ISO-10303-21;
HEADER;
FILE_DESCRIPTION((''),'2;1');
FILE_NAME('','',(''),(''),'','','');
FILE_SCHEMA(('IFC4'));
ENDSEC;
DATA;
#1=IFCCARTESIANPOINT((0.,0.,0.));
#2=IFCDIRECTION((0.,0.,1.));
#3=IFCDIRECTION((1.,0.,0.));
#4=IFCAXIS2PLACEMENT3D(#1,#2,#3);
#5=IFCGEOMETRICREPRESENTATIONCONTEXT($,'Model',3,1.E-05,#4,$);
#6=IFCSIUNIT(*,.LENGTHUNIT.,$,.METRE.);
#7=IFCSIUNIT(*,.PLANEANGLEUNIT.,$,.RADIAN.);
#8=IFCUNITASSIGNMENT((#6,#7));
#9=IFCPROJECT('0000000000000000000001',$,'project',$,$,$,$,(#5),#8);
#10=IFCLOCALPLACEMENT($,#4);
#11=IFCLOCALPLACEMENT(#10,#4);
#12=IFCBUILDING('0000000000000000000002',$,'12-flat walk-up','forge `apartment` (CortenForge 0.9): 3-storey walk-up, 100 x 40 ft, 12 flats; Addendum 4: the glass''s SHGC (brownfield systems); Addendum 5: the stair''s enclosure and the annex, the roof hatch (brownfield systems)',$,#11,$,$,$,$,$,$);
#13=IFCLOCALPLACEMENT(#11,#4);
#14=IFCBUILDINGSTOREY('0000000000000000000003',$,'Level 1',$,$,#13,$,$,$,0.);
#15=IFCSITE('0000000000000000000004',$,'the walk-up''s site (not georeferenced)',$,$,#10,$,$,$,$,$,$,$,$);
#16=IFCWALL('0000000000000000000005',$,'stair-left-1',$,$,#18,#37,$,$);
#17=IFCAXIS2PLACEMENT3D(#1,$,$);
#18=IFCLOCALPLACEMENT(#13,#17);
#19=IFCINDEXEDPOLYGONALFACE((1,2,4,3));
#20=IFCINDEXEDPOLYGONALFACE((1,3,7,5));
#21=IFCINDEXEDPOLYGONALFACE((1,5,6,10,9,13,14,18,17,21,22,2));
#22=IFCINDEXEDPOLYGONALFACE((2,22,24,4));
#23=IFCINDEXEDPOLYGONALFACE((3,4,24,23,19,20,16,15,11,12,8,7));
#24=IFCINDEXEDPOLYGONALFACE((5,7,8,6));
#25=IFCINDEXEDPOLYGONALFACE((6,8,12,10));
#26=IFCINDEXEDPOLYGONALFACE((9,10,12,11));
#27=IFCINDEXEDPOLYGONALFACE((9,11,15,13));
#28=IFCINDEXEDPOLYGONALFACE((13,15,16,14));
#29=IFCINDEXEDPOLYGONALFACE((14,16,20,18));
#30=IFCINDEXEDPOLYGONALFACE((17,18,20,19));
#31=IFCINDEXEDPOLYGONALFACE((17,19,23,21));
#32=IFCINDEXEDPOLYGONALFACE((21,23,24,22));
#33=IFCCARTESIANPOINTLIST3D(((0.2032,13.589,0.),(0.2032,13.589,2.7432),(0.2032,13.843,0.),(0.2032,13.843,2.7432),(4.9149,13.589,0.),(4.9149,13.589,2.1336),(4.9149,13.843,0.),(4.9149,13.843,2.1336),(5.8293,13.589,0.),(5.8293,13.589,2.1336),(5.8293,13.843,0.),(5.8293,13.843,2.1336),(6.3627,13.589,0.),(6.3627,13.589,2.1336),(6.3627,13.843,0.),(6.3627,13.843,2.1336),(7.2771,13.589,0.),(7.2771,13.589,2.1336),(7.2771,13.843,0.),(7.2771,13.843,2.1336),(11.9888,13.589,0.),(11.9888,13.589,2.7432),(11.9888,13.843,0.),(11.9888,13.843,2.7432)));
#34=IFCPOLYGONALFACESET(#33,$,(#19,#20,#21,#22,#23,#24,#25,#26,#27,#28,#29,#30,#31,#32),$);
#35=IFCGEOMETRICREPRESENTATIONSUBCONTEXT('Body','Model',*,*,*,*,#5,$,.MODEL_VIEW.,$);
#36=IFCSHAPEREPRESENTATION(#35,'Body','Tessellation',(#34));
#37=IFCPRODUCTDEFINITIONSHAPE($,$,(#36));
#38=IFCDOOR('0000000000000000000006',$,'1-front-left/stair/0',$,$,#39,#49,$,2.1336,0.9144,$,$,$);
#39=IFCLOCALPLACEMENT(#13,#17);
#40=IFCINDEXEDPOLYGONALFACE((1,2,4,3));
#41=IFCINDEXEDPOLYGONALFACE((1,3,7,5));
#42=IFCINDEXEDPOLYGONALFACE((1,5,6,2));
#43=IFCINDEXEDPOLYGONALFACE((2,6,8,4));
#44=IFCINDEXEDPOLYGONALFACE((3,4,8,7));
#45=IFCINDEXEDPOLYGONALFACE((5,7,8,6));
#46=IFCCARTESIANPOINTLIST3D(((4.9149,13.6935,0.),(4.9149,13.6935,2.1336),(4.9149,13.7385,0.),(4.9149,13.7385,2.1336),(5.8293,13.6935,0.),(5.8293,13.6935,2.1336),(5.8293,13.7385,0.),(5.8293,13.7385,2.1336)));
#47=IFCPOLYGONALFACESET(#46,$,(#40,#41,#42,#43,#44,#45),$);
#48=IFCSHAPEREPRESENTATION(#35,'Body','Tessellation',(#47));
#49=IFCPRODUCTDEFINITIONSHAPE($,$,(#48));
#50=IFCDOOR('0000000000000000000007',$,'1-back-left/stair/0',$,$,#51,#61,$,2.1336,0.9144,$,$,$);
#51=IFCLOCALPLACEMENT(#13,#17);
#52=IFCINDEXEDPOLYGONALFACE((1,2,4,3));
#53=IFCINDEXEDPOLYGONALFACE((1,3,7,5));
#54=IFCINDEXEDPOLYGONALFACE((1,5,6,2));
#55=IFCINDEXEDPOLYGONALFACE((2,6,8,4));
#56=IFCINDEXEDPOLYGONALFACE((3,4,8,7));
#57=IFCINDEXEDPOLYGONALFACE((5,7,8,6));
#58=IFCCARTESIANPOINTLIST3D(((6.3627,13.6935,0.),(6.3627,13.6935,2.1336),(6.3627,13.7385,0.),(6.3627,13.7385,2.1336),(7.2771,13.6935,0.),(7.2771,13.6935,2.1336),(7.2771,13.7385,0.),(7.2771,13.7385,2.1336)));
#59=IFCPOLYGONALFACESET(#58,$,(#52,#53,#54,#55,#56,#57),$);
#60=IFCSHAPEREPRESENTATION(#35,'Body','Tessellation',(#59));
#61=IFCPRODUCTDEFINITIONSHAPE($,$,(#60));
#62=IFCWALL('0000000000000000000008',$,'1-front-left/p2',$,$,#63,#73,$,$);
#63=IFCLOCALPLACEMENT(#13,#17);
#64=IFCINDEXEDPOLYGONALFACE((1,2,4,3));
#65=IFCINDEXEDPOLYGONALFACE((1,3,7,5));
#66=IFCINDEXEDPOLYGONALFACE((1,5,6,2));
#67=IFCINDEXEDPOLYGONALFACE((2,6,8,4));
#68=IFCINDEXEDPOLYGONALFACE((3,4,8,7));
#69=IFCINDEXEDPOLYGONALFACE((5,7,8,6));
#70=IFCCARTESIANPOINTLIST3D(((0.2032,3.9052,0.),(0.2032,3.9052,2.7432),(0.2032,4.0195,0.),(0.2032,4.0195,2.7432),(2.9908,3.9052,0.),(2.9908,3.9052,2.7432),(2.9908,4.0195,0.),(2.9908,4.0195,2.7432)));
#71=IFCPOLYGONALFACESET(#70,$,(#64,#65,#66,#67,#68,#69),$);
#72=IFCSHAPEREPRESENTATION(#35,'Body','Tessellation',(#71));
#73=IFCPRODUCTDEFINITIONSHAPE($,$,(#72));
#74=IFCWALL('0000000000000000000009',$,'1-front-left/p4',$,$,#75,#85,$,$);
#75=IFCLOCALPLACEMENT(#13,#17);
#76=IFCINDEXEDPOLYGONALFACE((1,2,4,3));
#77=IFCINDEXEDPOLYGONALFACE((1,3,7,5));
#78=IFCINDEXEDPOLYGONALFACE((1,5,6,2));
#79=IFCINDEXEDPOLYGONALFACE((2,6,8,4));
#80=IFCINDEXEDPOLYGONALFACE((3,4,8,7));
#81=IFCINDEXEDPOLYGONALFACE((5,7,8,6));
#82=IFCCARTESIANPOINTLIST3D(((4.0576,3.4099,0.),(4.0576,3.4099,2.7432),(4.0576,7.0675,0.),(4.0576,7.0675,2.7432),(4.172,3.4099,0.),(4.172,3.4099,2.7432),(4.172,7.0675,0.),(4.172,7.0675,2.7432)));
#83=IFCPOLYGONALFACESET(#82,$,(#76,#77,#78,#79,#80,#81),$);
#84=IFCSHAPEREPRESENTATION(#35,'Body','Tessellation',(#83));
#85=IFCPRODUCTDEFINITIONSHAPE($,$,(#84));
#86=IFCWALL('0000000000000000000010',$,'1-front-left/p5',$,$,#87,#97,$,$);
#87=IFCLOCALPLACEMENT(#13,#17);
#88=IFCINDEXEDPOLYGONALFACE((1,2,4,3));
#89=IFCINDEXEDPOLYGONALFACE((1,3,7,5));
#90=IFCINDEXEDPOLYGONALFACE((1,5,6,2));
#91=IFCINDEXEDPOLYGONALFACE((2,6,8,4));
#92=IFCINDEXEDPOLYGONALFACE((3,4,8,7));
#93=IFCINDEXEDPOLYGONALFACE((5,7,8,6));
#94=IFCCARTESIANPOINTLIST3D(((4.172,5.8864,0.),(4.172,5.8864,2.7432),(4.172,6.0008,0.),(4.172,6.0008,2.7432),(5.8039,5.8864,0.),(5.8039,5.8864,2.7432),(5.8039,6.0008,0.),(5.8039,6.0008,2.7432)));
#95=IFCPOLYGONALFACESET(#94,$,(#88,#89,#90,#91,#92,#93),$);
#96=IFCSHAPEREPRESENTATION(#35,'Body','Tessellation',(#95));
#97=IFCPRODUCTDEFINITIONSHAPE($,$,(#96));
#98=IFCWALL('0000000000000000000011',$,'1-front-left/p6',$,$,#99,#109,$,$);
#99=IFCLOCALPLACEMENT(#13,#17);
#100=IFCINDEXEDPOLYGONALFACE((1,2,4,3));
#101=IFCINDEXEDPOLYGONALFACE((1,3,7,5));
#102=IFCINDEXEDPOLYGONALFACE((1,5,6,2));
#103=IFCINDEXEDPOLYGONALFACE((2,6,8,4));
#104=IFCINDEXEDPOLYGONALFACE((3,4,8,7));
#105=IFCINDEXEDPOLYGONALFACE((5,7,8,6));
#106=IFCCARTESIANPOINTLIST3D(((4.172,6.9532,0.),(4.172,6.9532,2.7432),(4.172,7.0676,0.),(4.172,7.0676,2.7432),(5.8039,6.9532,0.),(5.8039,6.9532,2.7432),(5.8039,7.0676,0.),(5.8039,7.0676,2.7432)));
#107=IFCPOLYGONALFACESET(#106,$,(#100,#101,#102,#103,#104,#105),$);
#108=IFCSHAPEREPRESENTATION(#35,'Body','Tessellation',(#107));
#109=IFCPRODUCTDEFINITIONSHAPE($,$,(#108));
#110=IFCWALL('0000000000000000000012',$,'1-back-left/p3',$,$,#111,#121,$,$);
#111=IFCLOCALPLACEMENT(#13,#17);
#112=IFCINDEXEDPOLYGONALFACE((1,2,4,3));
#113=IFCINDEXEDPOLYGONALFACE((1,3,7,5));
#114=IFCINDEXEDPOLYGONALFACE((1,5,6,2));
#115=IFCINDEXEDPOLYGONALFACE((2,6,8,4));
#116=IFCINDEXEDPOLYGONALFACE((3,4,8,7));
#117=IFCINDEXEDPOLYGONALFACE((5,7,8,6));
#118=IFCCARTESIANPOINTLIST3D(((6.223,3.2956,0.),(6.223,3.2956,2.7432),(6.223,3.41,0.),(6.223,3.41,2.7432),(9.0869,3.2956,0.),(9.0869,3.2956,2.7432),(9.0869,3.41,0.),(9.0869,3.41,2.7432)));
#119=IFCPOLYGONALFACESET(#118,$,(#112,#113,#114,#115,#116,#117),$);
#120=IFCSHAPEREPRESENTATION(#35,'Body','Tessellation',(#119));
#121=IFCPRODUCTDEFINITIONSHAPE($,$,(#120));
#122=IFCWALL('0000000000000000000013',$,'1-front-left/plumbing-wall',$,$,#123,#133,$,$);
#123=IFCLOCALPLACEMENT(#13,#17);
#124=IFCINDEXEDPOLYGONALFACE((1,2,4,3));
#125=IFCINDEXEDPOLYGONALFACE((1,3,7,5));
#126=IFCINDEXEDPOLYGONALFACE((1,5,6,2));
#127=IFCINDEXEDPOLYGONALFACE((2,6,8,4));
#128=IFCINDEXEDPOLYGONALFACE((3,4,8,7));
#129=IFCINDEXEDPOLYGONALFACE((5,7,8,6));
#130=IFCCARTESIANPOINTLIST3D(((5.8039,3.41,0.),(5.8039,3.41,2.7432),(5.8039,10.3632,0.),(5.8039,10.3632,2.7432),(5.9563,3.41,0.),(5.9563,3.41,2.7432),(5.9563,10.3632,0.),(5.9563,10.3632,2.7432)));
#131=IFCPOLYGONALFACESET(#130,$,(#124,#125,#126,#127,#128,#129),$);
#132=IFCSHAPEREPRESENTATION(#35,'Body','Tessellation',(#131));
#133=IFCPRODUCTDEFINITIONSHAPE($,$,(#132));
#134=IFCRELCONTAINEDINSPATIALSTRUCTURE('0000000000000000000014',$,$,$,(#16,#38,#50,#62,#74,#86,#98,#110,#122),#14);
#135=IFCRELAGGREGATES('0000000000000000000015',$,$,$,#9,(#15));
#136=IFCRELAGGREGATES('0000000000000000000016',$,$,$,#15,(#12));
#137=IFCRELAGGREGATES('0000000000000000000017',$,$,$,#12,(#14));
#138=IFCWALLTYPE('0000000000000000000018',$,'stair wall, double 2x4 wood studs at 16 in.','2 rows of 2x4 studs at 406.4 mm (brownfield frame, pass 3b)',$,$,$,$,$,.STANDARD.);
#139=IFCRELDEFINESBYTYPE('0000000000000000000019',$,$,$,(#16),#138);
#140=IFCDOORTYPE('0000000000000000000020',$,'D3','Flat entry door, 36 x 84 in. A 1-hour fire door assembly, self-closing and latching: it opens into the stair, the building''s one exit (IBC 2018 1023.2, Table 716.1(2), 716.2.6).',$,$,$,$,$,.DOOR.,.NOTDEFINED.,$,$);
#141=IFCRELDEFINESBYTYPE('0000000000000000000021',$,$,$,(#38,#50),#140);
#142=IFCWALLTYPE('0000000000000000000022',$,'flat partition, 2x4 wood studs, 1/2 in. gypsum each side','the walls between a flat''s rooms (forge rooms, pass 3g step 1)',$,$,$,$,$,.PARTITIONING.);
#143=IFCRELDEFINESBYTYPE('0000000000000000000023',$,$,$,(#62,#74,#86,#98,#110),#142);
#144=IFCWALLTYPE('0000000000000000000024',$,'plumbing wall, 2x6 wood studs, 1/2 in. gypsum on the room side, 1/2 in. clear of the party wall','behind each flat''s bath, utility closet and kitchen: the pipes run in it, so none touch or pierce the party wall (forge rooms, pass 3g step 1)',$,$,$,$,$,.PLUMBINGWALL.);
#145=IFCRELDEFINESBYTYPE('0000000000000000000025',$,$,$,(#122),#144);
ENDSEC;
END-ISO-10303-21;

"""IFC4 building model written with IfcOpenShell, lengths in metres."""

from ifc_helpers import new_model, si_unit, frame, frame_2d, origin, origin_with_axes, place, context, subcontext, project, spatial, rectangle, extrude, type_object, element, fill, save


model = new_model("IFC4")

# Units and contexts
model_context = context("Model", 3, precision=1e-05, world=origin_with_axes())
body_context = subcontext(model_context, "Body", "Model", "MODEL_VIEW")
ifc_project = project(units=[si_unit("LENGTHUNIT", "METRE"), si_unit("PLANEANGLEUNIT", "RADIAN")], contexts=[model_context])

# Site, building, storey
site_placement = place(None, origin_with_axes())
site = spatial("IfcSite", under=ifc_project, at=site_placement, Name="the walk-up's site (not georeferenced)")
building_placement = place(site_placement, origin_with_axes())
building = spatial("IfcBuilding", under=site, at=building_placement, Name="12-flat walk-up", Description="forge `apartment` (CortenForge 0.9): 3-storey walk-up, 100 x 40 ft, 12 flats; Addendum 4: the glass's SHGC (brownfield systems); Addendum 5: the stair's enclosure and the annex, the roof hatch (brownfield systems)")
storey_placement = place(building_placement, origin_with_axes())
storey = spatial("IfcBuildingStorey", under=building, at=storey_placement, Name="Level 1", Elevation=0.0)

# Wall, openings, doors
wall_type_1 = type_object("IfcWallType", Name="stair wall, double 2x4 wood studs at 16 in.", Description="2 rows of 2x4 studs at 406.4 mm (brownfield frame, pass 3b)", PredefinedType="STANDARD")
wall_1_placement = place(storey_placement, frame((0.2032, 13.589, 0.0), z_axis=(0.0, 0.0, 1.0), x_axis=(1.0, 0.0, 0.0)))
wall_1 = element("IfcWall", 1, at=wall_1_placement, inside=storey, type_object=wall_type_1, Name="stair-left-1", context=body_context, shape_type="SweptSolid", body=[
    extrude(rectangle(XDim=11.7856, YDim=0.254, at=frame_2d((5.8928, 0.127))), origin(), (0.0, 0.0, 1.0), 2.7432),
])
opening_1_placement = place(wall_1_placement, frame((4.7117, 0.0, 0.0), z_axis=(0.0, 0.0, 1.0), x_axis=(1.0, 0.0, 0.0)))
opening_1 = element("IfcOpeningElement", 2, at=opening_1_placement, cuts=wall_1, PredefinedType="OPENING", context=body_context, shape_type="SweptSolid", body=[
    extrude(rectangle(XDim=0.9144, YDim=0.254, at=frame_2d((0.4572, 0.127))), origin(), (0.0, 0.0, 1.0), 2.1336),
])
opening_2_placement = place(wall_1_placement, frame((6.1595, 0.0, 0.0), z_axis=(0.0, 0.0, 1.0), x_axis=(1.0, 0.0, 0.0)))
opening_2 = element("IfcOpeningElement", 3, at=opening_2_placement, cuts=wall_1, PredefinedType="OPENING", context=body_context, shape_type="SweptSolid", body=[
    extrude(rectangle(XDim=0.9144, YDim=0.254, at=frame_2d((0.4572, 0.127))), origin(), (0.0, 0.0, 1.0), 2.1336),
])
door_type = type_object("IfcDoorType", Name="D3", Description="Flat entry door, 36 x 84 in. A 1-hour fire door assembly, self-closing and latching: it opens into the stair, the building's one exit (IBC 2018 1023.2, Table 716.1(2), 716.2.6).", OperationType="NOTDEFINED", PredefinedType="DOOR")
door_1_placement = place(opening_1_placement, frame((0.0, 0.1045, 0.0), z_axis=(0.0, 0.0, 1.0), x_axis=(1.0, 0.0, 0.0)))
door_1 = element("IfcDoor", 4, at=door_1_placement, inside=storey, type_object=door_type, Name="1-front-left/stair/0", OverallHeight=2.1336, OverallWidth=0.9144, context=body_context, shape_type="SweptSolid", body=[
    extrude(rectangle(XDim=0.9144, YDim=0.045, at=frame_2d((0.4572, 0.0225))), origin(), (0.0, 0.0, 1.0), 2.1336),
])
fill(opening_1, door_1)
door_2_placement = place(opening_2_placement, frame((0.0, 0.1045, 0.0), z_axis=(0.0, 0.0, 1.0), x_axis=(1.0, 0.0, 0.0)))
door_2 = element("IfcDoor", 5, at=door_2_placement, inside=storey, type_object=door_type, Name="1-back-left/stair/0", OverallHeight=2.1336, OverallWidth=0.9144, context=body_context, shape_type="SweptSolid", body=[
    extrude(rectangle(XDim=0.9144, YDim=0.045, at=frame_2d((0.4572, 0.0225))), origin(), (0.0, 0.0, 1.0), 2.1336),
])
fill(opening_2, door_2)

# Walls
wall_type_2 = type_object("IfcWallType", Name="flat partition, 2x4 wood studs, 1/2 in. gypsum each side", Description="the walls between a flat's rooms (forge rooms, pass 3g step 1)", PredefinedType="PARTITIONING")
wall_2_placement = place(storey_placement, frame((0.2032, 3.9052, 0.0), z_axis=(0.0, 0.0, 1.0), x_axis=(1.0, 0.0, 0.0)))
element("IfcWall", 6, at=wall_2_placement, inside=storey, type_object=wall_type_2, Name="1-front-left/p2", context=body_context, shape_type="SweptSolid", body=[
    extrude(rectangle(XDim=2.7877, YDim=0.1143, at=frame_2d((1.3938, 0.0571))), origin(), (0.0, 0.0, 1.0), 2.7432),
])
wall_3_placement = place(storey_placement, frame((4.0576, 3.4099, 0.0), z_axis=(0.0, 0.0, 1.0), x_axis=(1.0, 0.0, 0.0)))
element("IfcWall", 7, at=wall_3_placement, inside=storey, type_object=wall_type_2, Name="1-front-left/p4", context=body_context, shape_type="SweptSolid", body=[
    extrude(rectangle(XDim=0.1143, YDim=3.6576, at=frame_2d((0.0572, 1.8288))), origin(), (0.0, 0.0, 1.0), 2.7432),
])
for number, where, z_axis, x_axis, name in (
    (8, (4.1719, 5.8864, 0.0), (0.0, 0.0, 1.0), (1.0, 0.0, 0.0), "1-front-left/p5"),
    (9, (4.1719, 6.9532, 0.0), (0.0, 0.0, 1.0), (1.0, 0.0, 0.0), "1-front-left/p6"),
):
    element("IfcWall", number, at=place(storey_placement, frame(where, z_axis=z_axis, x_axis=x_axis)), inside=storey, type_object=wall_type_2, Name=name, context=body_context, shape_type="SweptSolid", body=[
        extrude(rectangle(XDim=1.6319, YDim=0.1143, at=frame_2d((0.816, 0.0572))), origin(), (0.0, 0.0, 1.0), 2.7432),
    ])
wall_4_placement = place(storey_placement, frame((6.223, 3.2957, 0.0), z_axis=(0.0, 0.0, 1.0), x_axis=(1.0, 0.0, 0.0)))
element("IfcWall", 10, at=wall_4_placement, inside=storey, type_object=wall_type_2, Name="1-back-left/p3", context=body_context, shape_type="SweptSolid", body=[
    extrude(rectangle(XDim=2.8639, YDim=0.1143, at=frame_2d((1.4319, 0.0571))), origin(), (0.0, 0.0, 1.0), 2.7432),
])
wall_type_3 = type_object("IfcWallType", Name="plumbing wall, 2x6 wood studs, 1/2 in. gypsum on the room side, 1/2 in. clear of the party wall", Description="behind each flat's bath, utility closet and kitchen: the pipes run in it, so none touch or pierce the party wall (forge rooms, pass 3g step 1)", PredefinedType="PLUMBINGWALL")
wall_5_placement = place(storey_placement, frame((5.8039, 3.41, 0.0), z_axis=(0.0, 0.0, 1.0), x_axis=(1.0, 0.0, 0.0)))
element("IfcWall", 11, at=wall_5_placement, inside=storey, type_object=wall_type_3, Name="1-front-left/plumbing-wall", context=body_context, shape_type="SweptSolid", body=[
    extrude(rectangle(XDim=0.1524, YDim=6.9533, at=frame_2d((0.0762, 3.4766))), origin(), (0.0, 0.0, 1.0), 2.7432),
])

save(model, "model.ifc")
